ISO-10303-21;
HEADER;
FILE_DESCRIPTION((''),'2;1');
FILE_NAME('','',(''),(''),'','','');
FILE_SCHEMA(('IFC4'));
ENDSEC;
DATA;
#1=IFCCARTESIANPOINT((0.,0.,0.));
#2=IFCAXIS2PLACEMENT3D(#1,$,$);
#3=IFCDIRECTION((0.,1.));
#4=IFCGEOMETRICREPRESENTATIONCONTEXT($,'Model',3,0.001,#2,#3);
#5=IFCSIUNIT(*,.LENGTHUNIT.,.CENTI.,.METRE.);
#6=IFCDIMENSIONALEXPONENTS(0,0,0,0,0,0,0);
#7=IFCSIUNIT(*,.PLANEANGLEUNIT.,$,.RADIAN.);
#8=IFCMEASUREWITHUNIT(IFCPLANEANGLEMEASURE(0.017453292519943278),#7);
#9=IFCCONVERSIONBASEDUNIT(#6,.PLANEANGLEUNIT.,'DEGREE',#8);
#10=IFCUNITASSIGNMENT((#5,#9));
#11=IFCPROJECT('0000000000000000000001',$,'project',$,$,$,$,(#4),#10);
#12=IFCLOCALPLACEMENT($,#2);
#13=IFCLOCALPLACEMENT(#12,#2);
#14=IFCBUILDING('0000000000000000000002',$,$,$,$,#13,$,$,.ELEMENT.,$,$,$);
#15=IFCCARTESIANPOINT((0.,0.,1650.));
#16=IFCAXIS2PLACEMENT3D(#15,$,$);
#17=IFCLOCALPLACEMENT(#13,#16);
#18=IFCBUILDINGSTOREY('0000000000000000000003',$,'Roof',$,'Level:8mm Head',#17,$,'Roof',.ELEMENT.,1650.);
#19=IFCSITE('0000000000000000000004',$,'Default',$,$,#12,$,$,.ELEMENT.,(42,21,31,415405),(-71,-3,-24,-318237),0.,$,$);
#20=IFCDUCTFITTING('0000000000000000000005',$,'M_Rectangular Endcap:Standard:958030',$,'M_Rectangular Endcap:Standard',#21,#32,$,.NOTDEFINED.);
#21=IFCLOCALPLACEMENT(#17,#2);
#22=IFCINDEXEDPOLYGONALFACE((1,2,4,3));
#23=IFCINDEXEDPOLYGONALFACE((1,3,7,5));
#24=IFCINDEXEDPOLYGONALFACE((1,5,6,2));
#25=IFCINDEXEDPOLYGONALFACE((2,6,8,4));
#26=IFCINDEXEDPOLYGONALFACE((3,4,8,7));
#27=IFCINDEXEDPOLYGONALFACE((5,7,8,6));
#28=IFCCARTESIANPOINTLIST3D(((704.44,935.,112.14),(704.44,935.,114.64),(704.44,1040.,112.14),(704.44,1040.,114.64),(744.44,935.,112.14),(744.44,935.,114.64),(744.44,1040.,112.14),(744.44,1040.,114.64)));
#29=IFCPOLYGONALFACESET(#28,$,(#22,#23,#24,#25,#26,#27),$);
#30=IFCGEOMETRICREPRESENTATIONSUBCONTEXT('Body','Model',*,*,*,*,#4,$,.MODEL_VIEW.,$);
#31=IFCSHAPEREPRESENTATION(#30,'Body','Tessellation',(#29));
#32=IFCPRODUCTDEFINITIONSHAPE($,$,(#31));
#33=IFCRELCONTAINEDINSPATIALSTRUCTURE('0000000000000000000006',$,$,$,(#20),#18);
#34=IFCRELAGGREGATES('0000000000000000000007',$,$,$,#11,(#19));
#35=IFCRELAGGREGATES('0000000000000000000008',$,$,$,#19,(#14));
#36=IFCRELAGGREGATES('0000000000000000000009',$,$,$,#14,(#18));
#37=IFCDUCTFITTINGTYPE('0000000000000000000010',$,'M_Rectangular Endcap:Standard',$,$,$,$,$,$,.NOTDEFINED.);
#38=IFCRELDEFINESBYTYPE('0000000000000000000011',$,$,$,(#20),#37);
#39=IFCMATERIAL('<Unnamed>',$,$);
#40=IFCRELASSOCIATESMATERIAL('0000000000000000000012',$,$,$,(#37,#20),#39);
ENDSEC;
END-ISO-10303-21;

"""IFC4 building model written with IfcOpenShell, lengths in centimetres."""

from ifc_helpers import new_model, entity, si_unit, converted_unit, direction, frame, origin, place, context, subcontext, project, spatial, indexed_curve, outline, extrude, source, transform, mapped, material, type_object, type_shapes, element, save


model = new_model("IFC4")

# Units and contexts
model_context = context("Model", 3, precision=0.001, world=origin(), true_north=direction((0.0, 1.0)))
body_context = subcontext(model_context, "Body", "Model", "MODEL_VIEW")
ifc_project = project(units=[si_unit("LENGTHUNIT", "METRE", prefix="CENTI"), converted_unit("PLANEANGLEUNIT", "DEGREE", entity("IfcPlaneAngleMeasure", 0.017453292519943278), si_unit("PLANEANGLEUNIT", "RADIAN"), dimensions=[0, 0, 0, 0, 0, 0, 0])], contexts=[model_context])

# Site, building, storey
site_placement = place(None, origin())
site = spatial("IfcSite", under=ifc_project, at=site_placement, Name="Default", CompositionType="ELEMENT", RefLatitude=(42, 21, 31, 415405), RefLongitude=(-71, -3, -24, -318237), RefElevation=0.0)
building_placement = place(site_placement, origin())
building = spatial("IfcBuilding", under=site, at=building_placement, CompositionType="ELEMENT")
storey_placement = place(building_placement, frame((0.0, 0.0, 1650.0)))
storey = spatial("IfcBuildingStorey", under=building, at=storey_placement, Name="Roof", ObjectType="Level:8mm Head", LongName="Roof", CompositionType="ELEMENT", Elevation=1650.0)

# Duct fitting
ifc_material = material(Name="<Unnamed>")
duct_fitting_type_1 = type_object("IfcDuctFittingType", Name="M_Rectangular Endcap:Standard", PredefinedType="NOTDEFINED", material=ifc_material)
shared_shape_1 = source(origin(), body_context, "Body", "SweptSolid", [
    extrude(outline(indexed_curve([(-1.25, -20.0), (1.25, -20.0), (1.25, 20.0), (-1.25, 20.0), (-1.25, -20.0)], self_intersect=False)), frame((1.25, 0.0, -52.5)), (0.0, 0.0, 1.0), 105.0),
])
type_shapes(duct_fitting_type_1, [shared_shape_1])
duct_fitting_1_placement = place(storey_placement, frame((724.44, 987.5, 112.14), z_axis=(0.0, -1.0, 0.0), x_axis=(0.0, 0.0, 1.0)))
element("IfcDuctFitting", 1, at=duct_fitting_1_placement, inside=storey, type_object=duct_fitting_type_1, material=ifc_material, Name="M_Rectangular Endcap:Standard:958030", ObjectType="M_Rectangular Endcap:Standard", PredefinedType="NOTDEFINED", context=body_context, shape_type="MappedRepresentation", body=[
    mapped(shared_shape_1, transform((0.0, 0.0, 0.0), scale=1.0)),
])

save(model, "model.ifc")
